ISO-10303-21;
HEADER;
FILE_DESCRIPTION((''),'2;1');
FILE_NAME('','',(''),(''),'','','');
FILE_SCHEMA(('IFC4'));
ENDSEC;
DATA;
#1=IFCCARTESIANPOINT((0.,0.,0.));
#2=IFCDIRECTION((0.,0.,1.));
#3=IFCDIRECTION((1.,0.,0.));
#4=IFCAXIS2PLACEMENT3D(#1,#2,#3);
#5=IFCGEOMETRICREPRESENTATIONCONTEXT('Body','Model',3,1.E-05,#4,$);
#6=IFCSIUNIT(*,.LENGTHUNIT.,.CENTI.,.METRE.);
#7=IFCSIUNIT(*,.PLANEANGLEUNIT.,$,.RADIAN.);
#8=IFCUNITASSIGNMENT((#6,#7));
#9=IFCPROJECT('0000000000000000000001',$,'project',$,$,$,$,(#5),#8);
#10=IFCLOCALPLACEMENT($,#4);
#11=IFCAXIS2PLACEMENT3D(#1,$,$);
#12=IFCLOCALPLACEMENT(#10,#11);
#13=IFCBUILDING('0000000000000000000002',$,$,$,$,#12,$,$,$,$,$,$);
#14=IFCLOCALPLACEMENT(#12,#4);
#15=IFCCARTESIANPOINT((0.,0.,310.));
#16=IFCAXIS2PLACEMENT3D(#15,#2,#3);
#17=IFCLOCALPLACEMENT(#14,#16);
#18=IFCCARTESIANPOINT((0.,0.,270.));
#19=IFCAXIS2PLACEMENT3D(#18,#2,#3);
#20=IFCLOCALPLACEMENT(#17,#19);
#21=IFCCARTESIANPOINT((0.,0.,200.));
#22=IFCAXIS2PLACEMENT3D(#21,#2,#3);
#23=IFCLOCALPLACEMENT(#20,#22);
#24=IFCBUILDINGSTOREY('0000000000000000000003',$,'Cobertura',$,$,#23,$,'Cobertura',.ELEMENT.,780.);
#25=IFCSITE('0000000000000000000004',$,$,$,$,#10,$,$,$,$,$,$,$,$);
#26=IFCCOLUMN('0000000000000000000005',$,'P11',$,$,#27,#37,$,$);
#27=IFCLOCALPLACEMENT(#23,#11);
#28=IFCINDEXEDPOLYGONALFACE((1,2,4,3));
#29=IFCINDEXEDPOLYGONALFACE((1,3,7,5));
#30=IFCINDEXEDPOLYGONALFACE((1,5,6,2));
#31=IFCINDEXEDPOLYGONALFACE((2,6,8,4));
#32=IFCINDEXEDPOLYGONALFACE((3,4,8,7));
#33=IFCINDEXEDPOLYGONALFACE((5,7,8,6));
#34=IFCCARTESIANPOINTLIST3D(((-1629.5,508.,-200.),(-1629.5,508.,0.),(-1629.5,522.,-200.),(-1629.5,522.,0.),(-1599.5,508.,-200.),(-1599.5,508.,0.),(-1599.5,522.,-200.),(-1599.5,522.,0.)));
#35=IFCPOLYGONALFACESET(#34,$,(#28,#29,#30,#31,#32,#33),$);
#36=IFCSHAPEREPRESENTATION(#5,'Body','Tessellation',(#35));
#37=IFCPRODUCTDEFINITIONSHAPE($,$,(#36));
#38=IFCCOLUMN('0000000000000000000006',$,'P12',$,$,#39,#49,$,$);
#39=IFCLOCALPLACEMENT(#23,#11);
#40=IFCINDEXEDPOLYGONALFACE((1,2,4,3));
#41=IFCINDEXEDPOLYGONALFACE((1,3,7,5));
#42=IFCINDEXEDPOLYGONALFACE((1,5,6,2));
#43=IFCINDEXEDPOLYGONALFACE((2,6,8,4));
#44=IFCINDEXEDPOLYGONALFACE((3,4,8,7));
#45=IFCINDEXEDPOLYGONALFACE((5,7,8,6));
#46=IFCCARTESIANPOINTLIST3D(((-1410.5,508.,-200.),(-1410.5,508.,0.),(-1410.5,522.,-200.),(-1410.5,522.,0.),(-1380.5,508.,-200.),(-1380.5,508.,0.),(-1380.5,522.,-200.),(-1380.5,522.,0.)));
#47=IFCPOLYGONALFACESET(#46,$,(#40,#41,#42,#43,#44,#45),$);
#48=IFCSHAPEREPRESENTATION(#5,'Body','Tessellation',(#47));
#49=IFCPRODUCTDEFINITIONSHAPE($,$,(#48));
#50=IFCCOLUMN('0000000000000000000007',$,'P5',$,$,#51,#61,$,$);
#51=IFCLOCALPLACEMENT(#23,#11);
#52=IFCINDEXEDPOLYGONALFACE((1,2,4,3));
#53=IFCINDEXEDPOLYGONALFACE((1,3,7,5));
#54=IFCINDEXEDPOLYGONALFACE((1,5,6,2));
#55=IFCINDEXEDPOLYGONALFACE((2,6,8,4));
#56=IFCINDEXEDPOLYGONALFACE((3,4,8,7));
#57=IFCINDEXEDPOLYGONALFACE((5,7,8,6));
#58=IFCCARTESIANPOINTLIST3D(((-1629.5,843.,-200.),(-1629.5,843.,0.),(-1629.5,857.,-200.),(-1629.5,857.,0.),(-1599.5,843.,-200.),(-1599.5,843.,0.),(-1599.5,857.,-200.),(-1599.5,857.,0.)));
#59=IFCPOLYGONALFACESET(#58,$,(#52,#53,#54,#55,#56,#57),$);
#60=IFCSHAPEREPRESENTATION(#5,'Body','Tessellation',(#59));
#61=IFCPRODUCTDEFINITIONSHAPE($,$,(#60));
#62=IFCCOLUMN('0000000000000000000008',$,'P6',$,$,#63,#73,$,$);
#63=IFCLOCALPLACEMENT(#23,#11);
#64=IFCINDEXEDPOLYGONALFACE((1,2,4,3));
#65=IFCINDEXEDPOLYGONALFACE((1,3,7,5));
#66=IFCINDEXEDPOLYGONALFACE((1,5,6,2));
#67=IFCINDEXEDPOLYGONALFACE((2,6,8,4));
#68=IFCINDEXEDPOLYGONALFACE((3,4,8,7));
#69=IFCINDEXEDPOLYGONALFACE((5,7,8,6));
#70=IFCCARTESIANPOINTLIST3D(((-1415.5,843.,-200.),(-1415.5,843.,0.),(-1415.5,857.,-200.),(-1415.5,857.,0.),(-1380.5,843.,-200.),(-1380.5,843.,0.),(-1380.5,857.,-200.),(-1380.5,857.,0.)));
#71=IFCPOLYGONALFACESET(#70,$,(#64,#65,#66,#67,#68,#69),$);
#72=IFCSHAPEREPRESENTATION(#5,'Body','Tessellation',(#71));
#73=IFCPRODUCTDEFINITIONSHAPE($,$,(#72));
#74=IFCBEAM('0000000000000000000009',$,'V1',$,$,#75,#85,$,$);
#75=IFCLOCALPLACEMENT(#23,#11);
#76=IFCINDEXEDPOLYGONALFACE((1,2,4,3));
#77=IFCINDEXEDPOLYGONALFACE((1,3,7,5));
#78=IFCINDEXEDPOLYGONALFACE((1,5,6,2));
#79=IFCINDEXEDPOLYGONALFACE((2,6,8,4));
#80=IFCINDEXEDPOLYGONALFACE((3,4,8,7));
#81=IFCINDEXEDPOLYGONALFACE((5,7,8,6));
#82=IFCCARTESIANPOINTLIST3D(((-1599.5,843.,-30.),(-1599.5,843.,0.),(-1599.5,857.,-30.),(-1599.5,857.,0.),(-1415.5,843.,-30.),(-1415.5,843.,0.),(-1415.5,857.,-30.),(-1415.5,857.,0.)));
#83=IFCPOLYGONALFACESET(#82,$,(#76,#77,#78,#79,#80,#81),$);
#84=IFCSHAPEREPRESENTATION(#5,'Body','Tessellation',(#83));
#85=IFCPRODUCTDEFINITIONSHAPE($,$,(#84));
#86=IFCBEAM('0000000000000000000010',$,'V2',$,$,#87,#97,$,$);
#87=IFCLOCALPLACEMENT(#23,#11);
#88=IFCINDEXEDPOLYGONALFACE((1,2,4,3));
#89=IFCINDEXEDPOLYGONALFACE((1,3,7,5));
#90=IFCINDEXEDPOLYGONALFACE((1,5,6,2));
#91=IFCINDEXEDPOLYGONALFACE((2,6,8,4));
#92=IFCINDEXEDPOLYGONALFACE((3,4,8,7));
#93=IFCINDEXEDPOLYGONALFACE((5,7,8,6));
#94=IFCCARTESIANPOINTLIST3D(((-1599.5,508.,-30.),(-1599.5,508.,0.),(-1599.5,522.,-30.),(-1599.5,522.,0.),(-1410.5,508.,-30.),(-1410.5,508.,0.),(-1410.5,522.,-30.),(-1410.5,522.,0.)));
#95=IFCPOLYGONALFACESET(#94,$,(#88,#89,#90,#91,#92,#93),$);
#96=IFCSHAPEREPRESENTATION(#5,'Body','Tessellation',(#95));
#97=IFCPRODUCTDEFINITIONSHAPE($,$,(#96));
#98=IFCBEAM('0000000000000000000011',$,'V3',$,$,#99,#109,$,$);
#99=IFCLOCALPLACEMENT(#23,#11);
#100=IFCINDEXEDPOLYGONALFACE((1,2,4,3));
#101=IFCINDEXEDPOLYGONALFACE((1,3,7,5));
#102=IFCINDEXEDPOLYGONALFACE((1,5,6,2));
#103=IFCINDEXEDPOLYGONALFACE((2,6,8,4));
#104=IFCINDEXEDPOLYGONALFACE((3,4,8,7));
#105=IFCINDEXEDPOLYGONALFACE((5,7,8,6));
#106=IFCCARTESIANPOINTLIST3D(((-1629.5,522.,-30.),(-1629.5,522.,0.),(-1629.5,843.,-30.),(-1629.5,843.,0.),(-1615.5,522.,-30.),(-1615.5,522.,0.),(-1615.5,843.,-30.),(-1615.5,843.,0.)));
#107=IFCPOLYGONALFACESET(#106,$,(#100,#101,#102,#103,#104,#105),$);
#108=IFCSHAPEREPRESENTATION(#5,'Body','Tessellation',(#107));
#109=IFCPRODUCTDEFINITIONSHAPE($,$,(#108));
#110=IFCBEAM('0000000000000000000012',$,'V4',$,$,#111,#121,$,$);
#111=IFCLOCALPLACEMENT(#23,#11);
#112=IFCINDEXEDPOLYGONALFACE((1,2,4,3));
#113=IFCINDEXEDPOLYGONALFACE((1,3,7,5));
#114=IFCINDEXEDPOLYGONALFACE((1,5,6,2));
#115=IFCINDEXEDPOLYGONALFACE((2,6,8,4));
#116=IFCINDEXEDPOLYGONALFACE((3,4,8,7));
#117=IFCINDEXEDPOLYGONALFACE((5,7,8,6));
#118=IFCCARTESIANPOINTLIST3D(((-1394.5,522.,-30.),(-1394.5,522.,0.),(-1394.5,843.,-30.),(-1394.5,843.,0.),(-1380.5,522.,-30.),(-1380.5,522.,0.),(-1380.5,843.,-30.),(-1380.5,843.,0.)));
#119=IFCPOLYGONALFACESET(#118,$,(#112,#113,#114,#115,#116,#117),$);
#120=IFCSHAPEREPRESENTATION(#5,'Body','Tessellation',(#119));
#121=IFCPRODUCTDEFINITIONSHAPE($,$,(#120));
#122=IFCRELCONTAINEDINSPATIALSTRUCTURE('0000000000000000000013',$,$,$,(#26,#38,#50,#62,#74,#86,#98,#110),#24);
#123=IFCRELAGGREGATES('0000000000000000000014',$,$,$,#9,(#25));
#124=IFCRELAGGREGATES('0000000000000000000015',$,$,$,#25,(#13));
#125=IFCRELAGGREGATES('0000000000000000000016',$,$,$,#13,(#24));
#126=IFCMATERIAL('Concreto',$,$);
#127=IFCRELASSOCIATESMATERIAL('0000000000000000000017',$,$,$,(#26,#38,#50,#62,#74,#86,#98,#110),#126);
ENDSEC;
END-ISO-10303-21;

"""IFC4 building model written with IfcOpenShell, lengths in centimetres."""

from ifc_helpers import new_model, si_unit, frame, origin, origin_with_axes, origin_2d_with_axis, place, context, project, spatial, rectangle, extrude, material, element, save


model = new_model("IFC4")

# Units and contexts
model_context = context("Model", 3, precision=1e-05, world=origin_with_axes(), identifier="Body")
ifc_project = project(units=[si_unit("LENGTHUNIT", "METRE", prefix="CENTI"), si_unit("PLANEANGLEUNIT", "RADIAN")], contexts=[model_context])

# Site, building, storey
site_placement = place(None, origin_with_axes())
site = spatial("IfcSite", under=ifc_project, at=site_placement)
building_placement = place(site_placement, origin())
building = spatial("IfcBuilding", under=site, at=building_placement)
placement_1 = place(building_placement, origin_with_axes())
placement_2 = place(placement_1, frame((0.0, 0.0, 310.0), z_axis=(0.0, 0.0, 1.0), x_axis=(1.0, 0.0, 0.0)))
placement_3 = place(placement_2, frame((0.0, 0.0, 270.0), z_axis=(0.0, 0.0, 1.0), x_axis=(1.0, 0.0, 0.0)))
storey_placement = place(placement_3, frame((0.0, 0.0, 200.0), z_axis=(0.0, 0.0, 1.0), x_axis=(1.0, 0.0, 0.0)))
storey = spatial("IfcBuildingStorey", under=building, at=storey_placement, Name="Cobertura", LongName="Cobertura", CompositionType="ELEMENT", Elevation=780.0)

# Columns
ifc_material = material(Name="Concreto")
for number, where, z_axis, x_axis, name in (
    (1, (-1614.5, 515.0, 0.0), (0.0, 0.0, 1.0), (1.0, 0.0, 0.0), "P11"),
    (2, (-1395.5, 515.0, 0.0), (0.0, 0.0, 1.0), (1.0, 0.0, 0.0), "P12"),
):
    element("IfcColumn", number, at=place(storey_placement, frame(where, z_axis=z_axis, x_axis=x_axis)), inside=storey, material=ifc_material, Name=name, context=model_context, shape_type="SolidModel", body=[
        extrude(rectangle(XDim=14.0, YDim=30.0, at=origin_2d_with_axis()), frame((0.0, 0.0, 0.0), z_axis=(0.0, 0.0, 1.0), x_axis=(0.0, 1.0, 0.0)), (0.0, 0.0, -1.0), 200.0),
    ])
column_1_placement = place(storey_placement, frame((-1614.5, 850.0, 0.0), z_axis=(0.0, 0.0, 1.0), x_axis=(1.0, 0.0, 0.0)))
element("IfcColumn", 3, at=column_1_placement, inside=storey, material=ifc_material, Name="P5", context=model_context, shape_type="SolidModel", body=[
    extrude(rectangle(XDim=14.0, YDim=30.0, at=origin_2d_with_axis()), frame((0.0, 0.0, 0.0), z_axis=(0.0, 0.0, 1.0), x_axis=(0.0, -1.0, 0.0)), (0.0, 0.0, -1.0), 200.0),
])
column_2_placement = place(storey_placement, frame((-1398.0, 850.0, 0.0), z_axis=(0.0, 0.0, 1.0), x_axis=(1.0, 0.0, 0.0)))
element("IfcColumn", 4, at=column_2_placement, inside=storey, material=ifc_material, Name="P6", context=model_context, shape_type="SolidModel", body=[
    extrude(rectangle(XDim=14.0, YDim=35.0, at=origin_2d_with_axis()), frame((0.0, 0.0, 0.0), z_axis=(0.0, 0.0, 1.0), x_axis=(0.0, 1.0, 0.0)), (0.0, 0.0, -1.0), 200.0),
])

# Beams
beam_1_placement = place(storey_placement, frame((-1507.5, 850.0, 0.0), z_axis=(0.0, 0.0, 1.0), x_axis=(1.0, 0.0, 0.0)))
element("IfcBeam", 5, at=beam_1_placement, inside=storey, material=ifc_material, Name="V1", context=model_context, shape_type="SolidModel", body=[
    extrude(rectangle(XDim=14.0, YDim=30.0, at=origin_2d_with_axis()), frame((-92.0, 0.0, -15.0), z_axis=(1.0, 0.0, 0.0), x_axis=(0.0, -1.0, 0.0)), (0.0, 0.0, 1.0), 184.0),
])
beam_2_placement = place(storey_placement, frame((-1505.0, 515.0, 0.0), z_axis=(0.0, 0.0, 1.0), x_axis=(1.0, 0.0, 0.0)))
element("IfcBeam", 6, at=beam_2_placement, inside=storey, material=ifc_material, Name="V2", context=model_context, shape_type="SolidModel", body=[
    extrude(rectangle(XDim=14.0, YDim=30.0, at=origin_2d_with_axis()), frame((-94.5, 0.0, -15.0), z_axis=(1.0, 0.0, 0.0), x_axis=(0.0, -1.0, 0.0)), (0.0, 0.0, 1.0), 189.0),
])
for number, where, z_axis, x_axis, name in (
    (7, (-1622.5, 682.5, 0.0), (0.0, 0.0, 1.0), (1.0, 0.0, 0.0), "V3"),
    (8, (-1387.5, 682.5, 0.0), (0.0, 0.0, 1.0), (1.0, 0.0, 0.0), "V4"),
):
    element("IfcBeam", number, at=place(storey_placement, frame(where, z_axis=z_axis, x_axis=x_axis)), inside=storey, material=ifc_material, Name=name, context=model_context, shape_type="SolidModel", body=[
        extrude(rectangle(XDim=14.0, YDim=30.0, at=origin_2d_with_axis()), frame((0.0, -160.5, -15.0), z_axis=(0.0, 1.0, 0.0), x_axis=(-1.0, 0.0, 0.0)), (0.0, 0.0, 1.0), 321.0),
    ])

save(model, "model.ifc")
